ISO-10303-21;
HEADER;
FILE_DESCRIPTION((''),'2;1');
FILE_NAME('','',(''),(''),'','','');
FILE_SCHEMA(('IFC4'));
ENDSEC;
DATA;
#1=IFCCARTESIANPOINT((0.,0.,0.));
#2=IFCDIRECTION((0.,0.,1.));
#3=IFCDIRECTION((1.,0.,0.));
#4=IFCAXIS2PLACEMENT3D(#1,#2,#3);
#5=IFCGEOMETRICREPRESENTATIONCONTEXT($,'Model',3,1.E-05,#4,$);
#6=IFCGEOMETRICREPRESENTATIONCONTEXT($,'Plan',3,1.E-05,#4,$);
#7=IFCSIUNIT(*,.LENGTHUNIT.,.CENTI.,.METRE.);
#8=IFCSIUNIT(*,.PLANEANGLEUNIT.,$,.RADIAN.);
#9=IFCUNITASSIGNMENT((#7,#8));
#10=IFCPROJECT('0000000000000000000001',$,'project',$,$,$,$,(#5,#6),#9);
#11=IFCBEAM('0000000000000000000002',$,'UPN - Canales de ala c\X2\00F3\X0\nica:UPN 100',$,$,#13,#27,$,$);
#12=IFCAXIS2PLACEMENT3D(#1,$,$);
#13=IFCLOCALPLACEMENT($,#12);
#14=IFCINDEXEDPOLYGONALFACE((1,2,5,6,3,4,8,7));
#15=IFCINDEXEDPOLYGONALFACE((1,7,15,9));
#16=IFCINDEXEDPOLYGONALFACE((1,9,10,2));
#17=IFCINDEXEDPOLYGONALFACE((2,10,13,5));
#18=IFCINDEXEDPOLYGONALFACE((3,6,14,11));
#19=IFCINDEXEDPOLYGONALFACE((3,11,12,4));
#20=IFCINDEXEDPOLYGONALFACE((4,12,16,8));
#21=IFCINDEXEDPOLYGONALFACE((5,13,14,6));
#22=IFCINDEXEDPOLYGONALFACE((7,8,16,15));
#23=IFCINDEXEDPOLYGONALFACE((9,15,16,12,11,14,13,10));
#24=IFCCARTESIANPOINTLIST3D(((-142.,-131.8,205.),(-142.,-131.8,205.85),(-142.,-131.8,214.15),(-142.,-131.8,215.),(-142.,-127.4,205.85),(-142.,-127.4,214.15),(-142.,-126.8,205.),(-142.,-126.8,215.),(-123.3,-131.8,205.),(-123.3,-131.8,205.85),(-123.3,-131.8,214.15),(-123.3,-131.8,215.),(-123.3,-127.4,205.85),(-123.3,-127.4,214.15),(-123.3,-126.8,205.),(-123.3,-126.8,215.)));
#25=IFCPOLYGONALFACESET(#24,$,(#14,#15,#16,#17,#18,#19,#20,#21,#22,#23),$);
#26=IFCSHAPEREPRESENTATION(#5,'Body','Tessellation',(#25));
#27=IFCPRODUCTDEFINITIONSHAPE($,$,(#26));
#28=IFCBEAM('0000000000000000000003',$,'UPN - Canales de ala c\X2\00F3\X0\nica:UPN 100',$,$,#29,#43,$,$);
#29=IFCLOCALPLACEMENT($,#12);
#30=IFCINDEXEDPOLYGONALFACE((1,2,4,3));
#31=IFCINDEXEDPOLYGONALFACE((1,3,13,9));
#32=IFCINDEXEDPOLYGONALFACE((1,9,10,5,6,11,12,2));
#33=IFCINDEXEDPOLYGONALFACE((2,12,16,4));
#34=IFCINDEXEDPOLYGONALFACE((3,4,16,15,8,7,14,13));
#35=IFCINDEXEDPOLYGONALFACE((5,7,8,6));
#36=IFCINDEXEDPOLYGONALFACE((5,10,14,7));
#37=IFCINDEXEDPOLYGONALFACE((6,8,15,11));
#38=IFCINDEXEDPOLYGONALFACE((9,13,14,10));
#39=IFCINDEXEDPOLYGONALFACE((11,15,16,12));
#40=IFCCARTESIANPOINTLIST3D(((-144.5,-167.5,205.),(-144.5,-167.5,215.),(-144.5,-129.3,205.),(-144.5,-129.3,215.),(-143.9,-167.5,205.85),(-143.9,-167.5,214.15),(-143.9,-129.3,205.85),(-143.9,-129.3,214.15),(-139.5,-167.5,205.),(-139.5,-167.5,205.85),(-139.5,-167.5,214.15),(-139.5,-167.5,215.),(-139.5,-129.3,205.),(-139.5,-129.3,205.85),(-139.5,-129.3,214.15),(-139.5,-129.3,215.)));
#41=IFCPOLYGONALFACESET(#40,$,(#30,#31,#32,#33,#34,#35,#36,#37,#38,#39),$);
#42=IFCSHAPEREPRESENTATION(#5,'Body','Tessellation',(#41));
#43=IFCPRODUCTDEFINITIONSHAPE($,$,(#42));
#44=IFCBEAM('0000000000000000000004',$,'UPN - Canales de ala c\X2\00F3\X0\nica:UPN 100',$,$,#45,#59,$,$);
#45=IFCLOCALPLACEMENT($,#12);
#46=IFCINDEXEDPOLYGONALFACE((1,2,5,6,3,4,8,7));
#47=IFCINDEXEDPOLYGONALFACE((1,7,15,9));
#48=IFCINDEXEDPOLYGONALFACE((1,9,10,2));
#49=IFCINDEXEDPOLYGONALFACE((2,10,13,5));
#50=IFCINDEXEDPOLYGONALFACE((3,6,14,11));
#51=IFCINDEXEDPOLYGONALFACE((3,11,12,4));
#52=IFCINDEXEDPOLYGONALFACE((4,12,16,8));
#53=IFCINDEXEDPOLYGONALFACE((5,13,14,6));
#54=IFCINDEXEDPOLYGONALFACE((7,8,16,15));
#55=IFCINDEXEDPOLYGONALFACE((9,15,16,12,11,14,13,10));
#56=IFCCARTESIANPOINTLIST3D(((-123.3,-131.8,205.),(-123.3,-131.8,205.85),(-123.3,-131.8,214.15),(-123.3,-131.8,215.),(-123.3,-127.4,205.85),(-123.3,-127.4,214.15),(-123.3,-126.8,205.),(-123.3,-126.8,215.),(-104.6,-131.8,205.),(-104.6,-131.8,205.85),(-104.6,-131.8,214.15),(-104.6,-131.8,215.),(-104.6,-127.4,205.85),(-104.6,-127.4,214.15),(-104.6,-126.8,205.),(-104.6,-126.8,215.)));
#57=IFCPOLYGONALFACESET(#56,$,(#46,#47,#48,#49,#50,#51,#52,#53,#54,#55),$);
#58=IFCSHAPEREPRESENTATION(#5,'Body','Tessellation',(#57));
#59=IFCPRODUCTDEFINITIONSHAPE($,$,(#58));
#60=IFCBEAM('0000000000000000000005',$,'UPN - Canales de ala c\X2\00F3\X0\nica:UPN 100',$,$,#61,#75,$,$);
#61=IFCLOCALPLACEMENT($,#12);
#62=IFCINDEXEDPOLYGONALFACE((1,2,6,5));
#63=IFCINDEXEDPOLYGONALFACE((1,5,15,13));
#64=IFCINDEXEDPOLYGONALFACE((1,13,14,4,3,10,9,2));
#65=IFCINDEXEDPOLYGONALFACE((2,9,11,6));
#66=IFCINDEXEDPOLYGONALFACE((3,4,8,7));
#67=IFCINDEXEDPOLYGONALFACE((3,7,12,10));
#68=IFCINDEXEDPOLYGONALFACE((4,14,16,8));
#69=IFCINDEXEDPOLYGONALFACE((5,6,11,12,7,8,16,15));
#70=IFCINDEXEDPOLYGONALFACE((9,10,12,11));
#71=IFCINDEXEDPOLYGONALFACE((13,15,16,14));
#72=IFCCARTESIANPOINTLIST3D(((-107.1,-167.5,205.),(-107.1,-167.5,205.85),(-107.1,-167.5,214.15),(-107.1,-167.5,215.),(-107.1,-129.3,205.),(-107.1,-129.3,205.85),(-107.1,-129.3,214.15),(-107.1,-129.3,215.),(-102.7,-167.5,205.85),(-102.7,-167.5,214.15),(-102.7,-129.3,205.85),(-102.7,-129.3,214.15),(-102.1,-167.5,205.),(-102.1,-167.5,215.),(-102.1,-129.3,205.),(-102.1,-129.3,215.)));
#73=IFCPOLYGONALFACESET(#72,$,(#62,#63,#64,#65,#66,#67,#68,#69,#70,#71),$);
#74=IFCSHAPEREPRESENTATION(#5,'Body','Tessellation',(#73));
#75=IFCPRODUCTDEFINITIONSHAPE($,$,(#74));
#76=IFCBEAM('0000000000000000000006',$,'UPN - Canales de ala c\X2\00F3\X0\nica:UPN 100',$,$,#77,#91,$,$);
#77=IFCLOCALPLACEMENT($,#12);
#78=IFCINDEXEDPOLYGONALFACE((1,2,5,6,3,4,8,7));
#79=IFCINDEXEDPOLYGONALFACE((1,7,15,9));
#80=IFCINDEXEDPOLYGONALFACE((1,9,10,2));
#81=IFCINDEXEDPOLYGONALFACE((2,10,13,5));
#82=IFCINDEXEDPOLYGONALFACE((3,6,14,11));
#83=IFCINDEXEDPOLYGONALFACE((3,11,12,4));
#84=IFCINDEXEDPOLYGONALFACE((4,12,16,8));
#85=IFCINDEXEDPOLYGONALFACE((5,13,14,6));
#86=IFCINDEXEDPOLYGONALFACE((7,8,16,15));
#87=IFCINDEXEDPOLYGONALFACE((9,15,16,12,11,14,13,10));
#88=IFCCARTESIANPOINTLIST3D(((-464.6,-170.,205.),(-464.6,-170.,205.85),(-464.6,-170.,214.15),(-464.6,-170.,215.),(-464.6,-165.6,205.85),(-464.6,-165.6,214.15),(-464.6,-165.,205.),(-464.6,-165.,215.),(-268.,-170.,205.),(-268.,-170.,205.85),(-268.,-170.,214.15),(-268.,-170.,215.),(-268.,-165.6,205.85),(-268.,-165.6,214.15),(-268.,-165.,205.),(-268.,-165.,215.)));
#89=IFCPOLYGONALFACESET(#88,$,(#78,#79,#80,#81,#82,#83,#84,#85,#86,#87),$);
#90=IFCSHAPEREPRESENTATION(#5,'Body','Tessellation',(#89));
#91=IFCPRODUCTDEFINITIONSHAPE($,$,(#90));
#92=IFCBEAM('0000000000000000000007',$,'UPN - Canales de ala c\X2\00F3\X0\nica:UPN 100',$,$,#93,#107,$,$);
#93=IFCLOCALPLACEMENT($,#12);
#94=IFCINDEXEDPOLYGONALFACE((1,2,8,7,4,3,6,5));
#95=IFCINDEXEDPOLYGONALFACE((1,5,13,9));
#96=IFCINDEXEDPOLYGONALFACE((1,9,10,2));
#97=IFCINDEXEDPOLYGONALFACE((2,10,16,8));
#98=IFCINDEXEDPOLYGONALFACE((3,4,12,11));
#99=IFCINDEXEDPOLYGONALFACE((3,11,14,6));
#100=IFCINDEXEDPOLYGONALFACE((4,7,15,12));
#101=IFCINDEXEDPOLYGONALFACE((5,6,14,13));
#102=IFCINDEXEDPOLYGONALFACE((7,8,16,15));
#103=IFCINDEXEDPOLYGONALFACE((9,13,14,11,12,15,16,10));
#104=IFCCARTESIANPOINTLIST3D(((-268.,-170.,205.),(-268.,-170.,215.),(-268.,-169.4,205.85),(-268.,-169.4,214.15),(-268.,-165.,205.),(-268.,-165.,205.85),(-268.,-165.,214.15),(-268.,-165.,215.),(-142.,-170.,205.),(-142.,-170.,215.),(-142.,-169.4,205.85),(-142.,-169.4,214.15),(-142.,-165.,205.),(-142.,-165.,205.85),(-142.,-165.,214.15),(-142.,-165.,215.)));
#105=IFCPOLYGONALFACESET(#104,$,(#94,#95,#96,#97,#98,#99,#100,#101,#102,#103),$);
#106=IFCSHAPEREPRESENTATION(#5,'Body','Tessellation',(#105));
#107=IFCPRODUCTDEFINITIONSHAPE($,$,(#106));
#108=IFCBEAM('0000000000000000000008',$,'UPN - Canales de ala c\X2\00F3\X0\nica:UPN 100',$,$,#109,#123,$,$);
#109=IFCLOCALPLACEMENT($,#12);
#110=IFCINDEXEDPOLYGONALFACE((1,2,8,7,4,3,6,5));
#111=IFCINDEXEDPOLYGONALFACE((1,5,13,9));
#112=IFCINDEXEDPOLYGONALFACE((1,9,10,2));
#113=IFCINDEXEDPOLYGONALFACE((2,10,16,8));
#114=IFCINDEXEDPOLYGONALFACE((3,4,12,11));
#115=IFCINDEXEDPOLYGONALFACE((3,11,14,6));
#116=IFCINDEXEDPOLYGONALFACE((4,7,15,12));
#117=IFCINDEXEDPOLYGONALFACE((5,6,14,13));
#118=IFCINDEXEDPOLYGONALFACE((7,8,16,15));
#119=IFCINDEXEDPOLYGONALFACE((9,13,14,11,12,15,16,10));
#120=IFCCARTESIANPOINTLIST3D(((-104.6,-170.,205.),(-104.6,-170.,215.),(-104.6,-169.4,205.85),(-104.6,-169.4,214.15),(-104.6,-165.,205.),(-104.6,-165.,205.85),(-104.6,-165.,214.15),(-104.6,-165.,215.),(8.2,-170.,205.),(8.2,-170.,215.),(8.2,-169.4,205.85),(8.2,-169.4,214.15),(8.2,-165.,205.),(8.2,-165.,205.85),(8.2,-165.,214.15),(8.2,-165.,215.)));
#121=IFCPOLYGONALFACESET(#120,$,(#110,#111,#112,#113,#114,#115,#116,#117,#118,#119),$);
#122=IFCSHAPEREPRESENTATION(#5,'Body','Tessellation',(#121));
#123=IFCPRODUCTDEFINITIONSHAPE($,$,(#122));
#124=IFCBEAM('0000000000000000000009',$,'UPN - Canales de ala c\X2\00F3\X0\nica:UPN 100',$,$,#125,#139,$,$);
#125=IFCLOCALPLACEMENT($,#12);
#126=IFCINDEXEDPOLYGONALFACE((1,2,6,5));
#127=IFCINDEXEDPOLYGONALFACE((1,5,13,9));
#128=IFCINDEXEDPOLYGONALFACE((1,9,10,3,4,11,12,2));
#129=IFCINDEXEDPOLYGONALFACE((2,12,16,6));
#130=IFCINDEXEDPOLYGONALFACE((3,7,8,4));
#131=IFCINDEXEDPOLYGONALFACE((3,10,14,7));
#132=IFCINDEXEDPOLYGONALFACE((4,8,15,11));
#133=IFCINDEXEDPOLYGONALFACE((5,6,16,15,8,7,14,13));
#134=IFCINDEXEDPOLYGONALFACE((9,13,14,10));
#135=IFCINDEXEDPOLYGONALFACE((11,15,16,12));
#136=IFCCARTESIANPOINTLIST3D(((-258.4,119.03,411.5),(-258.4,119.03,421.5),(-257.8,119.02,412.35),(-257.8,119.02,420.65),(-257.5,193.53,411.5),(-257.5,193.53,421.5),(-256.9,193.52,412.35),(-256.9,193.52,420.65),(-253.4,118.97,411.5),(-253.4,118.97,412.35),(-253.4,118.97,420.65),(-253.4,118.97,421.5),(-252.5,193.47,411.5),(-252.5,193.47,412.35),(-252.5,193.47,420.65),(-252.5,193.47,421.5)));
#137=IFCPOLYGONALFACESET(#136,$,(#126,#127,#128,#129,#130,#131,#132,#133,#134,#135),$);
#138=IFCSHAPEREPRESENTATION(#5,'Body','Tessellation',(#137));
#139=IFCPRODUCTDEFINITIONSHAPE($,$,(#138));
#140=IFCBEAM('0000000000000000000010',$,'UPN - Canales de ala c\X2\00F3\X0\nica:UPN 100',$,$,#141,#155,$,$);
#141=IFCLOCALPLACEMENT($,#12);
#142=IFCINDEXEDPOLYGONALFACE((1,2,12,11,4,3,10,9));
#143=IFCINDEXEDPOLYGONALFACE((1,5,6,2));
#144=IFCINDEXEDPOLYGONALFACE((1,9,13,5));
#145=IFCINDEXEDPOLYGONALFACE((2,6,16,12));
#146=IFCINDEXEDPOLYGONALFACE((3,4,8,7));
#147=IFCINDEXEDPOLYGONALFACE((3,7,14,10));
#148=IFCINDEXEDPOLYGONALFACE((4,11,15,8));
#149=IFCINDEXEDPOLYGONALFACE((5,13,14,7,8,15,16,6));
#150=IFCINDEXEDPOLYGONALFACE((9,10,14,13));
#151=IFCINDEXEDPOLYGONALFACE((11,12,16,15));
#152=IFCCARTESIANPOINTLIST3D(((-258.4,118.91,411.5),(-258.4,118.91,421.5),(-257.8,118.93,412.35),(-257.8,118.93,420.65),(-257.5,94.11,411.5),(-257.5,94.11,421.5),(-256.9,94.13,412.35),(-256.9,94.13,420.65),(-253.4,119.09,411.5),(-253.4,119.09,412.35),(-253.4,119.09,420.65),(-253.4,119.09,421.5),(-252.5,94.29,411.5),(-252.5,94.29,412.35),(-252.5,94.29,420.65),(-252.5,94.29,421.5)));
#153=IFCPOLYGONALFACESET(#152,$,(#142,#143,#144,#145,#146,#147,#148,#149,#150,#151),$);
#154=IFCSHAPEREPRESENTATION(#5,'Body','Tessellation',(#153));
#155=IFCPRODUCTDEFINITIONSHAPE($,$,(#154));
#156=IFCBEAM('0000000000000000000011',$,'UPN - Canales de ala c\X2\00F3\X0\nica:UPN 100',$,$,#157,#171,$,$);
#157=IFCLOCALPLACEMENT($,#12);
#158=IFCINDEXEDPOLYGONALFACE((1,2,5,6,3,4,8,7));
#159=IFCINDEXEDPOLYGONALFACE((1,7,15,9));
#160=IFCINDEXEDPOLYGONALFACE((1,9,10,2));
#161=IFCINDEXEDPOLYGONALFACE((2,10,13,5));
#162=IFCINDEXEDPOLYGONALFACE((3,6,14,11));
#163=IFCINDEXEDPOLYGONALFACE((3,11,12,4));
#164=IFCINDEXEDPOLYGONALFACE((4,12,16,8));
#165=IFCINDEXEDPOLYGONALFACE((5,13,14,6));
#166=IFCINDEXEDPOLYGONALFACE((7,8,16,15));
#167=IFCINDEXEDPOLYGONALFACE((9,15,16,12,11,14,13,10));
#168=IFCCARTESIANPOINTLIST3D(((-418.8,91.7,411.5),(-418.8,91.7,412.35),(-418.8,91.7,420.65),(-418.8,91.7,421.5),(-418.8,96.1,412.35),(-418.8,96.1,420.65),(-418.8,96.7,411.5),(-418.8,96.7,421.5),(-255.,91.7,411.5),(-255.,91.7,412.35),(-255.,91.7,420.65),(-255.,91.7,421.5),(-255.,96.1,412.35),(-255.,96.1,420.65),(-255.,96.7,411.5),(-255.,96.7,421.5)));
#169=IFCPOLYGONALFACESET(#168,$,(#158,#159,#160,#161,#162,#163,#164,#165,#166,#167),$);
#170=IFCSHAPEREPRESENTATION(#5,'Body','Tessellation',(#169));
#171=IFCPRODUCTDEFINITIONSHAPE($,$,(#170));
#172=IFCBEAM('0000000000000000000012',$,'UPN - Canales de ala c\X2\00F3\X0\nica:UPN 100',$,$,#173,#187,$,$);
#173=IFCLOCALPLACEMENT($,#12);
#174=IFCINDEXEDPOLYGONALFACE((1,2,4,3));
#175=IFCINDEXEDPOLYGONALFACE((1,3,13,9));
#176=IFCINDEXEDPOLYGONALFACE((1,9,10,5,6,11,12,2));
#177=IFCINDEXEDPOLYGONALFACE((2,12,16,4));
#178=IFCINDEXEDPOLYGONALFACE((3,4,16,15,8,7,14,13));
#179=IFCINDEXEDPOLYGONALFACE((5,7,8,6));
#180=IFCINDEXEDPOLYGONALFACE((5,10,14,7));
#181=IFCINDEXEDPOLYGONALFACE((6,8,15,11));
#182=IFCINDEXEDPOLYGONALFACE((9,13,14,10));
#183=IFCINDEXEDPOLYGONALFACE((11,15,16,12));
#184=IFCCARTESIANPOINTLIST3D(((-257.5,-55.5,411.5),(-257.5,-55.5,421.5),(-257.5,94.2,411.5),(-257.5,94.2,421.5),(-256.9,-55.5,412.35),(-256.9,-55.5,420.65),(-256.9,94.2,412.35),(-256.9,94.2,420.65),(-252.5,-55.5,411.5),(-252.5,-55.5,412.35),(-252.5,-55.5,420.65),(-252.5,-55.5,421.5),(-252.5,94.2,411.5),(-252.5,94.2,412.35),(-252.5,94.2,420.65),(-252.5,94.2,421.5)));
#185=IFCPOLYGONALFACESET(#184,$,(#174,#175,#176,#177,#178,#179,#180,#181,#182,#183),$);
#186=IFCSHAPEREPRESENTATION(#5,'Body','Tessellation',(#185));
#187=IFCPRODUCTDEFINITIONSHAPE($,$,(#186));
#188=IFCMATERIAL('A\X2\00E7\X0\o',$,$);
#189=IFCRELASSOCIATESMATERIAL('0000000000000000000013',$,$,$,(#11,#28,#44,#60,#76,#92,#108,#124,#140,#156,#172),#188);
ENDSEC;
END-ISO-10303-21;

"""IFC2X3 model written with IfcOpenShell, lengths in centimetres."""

from ifc_helpers import new_model, si_unit, frame, frame_2d, origin_with_axes, origin_2d_with_axis, place, context, project, u_section, extrude, material, element, save


model = new_model("IFC2X3")

# Units and contexts
model_context = context("Model", 3, precision=1e-05, world=origin_with_axes())
plan_context = context("Plan", 3, precision=1e-05, world=origin_with_axes())
ifc_project = project(units=[si_unit("LENGTHUNIT", "METRE", prefix="CENTI"), si_unit("PLANEANGLEUNIT", "RADIAN")], contexts=[model_context, plan_context])

# Shared definitions
ifc_material = material(Name="Aço")

# Beams
beam_1_placement = place(None, frame((-123.3, -129.3, 210.0), z_axis=(-1.0, 0.0, 0.0), x_axis=(0.0, -1.0, 0.0)))
element("IfcBeam", 1, at=beam_1_placement, material=ifc_material, Name="UPN - Canales de ala cónica:UPN 100", context=model_context, shape_type="SweptSolid", body=[
    extrude(u_section(Depth=10.0, FlangeWidth=5.0, WebThickness=0.6, FlangeThickness=0.85, FilletRadius=0.0, EdgeRadius=0.0, FlangeSlope=0.0, CentreOfGravityInX=0.0, at=origin_2d_with_axis()), origin_with_axes(), (0.0, 0.0, 1.0), 18.7),
])
beam_2_placement = place(None, frame((-142.0, -167.5, 210.0), z_axis=(0.0, 1.0, 0.0), x_axis=(1.0, 0.0, 0.0)))
element("IfcBeam", 2, at=beam_2_placement, material=ifc_material, Name="UPN - Canales de ala cónica:UPN 100", context=model_context, shape_type="SweptSolid", body=[
    extrude(u_section(Depth=10.0, FlangeWidth=5.0, WebThickness=0.6, FlangeThickness=0.85, FilletRadius=0.0, EdgeRadius=0.0, FlangeSlope=0.0, CentreOfGravityInX=0.0, at=origin_2d_with_axis()), origin_with_axes(), (0.0, 0.0, 1.0), 38.2),
])
beam_3_placement = place(None, frame((-104.6, -129.3, 210.0), z_axis=(-1.0, 0.0, 0.0), x_axis=(0.0, -1.0, 0.0)))
element("IfcBeam", 3, at=beam_3_placement, material=ifc_material, Name="UPN - Canales de ala cónica:UPN 100", context=model_context, shape_type="SweptSolid", body=[
    extrude(u_section(Depth=10.0, FlangeWidth=5.0, WebThickness=0.6, FlangeThickness=0.85, FilletRadius=0.0, EdgeRadius=0.0, FlangeSlope=0.0, CentreOfGravityInX=0.0, at=origin_2d_with_axis()), origin_with_axes(), (0.0, 0.0, 1.0), 18.7),
])
beam_4_placement = place(None, frame((-104.6, -167.5, 210.0), z_axis=(0.0, 1.0, 0.0), x_axis=(-1.0, 0.0, 0.0)))
element("IfcBeam", 4, at=beam_4_placement, material=ifc_material, Name="UPN - Canales de ala cónica:UPN 100", context=model_context, shape_type="SweptSolid", body=[
    extrude(u_section(Depth=10.0, FlangeWidth=5.0, WebThickness=0.6, FlangeThickness=0.85, FilletRadius=0.0, EdgeRadius=0.0, FlangeSlope=0.0, CentreOfGravityInX=0.0, at=origin_2d_with_axis()), origin_with_axes(), (0.0, 0.0, 1.0), 38.2),
])
beam_5_placement = place(None, frame((-268.0, -167.5, 210.0), z_axis=(-1.0, 0.0, 0.0), x_axis=(0.0, -1.0, 0.0)))
element("IfcBeam", 5, at=beam_5_placement, material=ifc_material, Name="UPN - Canales de ala cónica:UPN 100", context=model_context, shape_type="SweptSolid", body=[
    extrude(u_section(Depth=10.0, FlangeWidth=5.0, WebThickness=0.6, FlangeThickness=0.85, FilletRadius=0.0, EdgeRadius=0.0, FlangeSlope=0.0, CentreOfGravityInX=0.0, at=origin_2d_with_axis()), origin_with_axes(), (0.0, 0.0, 1.0), 196.6),
])
beam_6_placement = place(None, frame((-142.0, -167.5, 210.0), z_axis=(-1.0, 0.0, 0.0), x_axis=(0.0, 1.0, 0.0)))
element("IfcBeam", 6, at=beam_6_placement, material=ifc_material, Name="UPN - Canales de ala cónica:UPN 100", context=model_context, shape_type="SweptSolid", body=[
    extrude(u_section(Depth=10.0, FlangeWidth=5.0, WebThickness=0.6, FlangeThickness=0.85, FilletRadius=0.0, EdgeRadius=0.0, FlangeSlope=0.0, CentreOfGravityInX=0.0, at=origin_2d_with_axis()), origin_with_axes(), (0.0, 0.0, 1.0), 126.0),
])
beam_7_placement = place(None, frame((8.2, -167.5, 210.0), z_axis=(-1.0, 0.0, 0.0), x_axis=(0.0, 1.0, 0.0)))
element("IfcBeam", 7, at=beam_7_placement, material=ifc_material, Name="UPN - Canales de ala cónica:UPN 100", context=model_context, shape_type="SweptSolid", body=[
    extrude(u_section(Depth=10.0, FlangeWidth=5.0, WebThickness=0.6, FlangeThickness=0.85, FilletRadius=0.0, EdgeRadius=0.0, FlangeSlope=0.0, CentreOfGravityInX=0.0, at=origin_2d_with_axis()), origin_with_axes(), (0.0, 0.0, 1.0), 112.8),
])
beam_8_placement = place(None, frame((-255.9, 119.0, 416.5), z_axis=(0.01208, 0.999927, 0.0), x_axis=(0.999927, -0.01208, 0.0)))
element("IfcBeam", 8, at=beam_8_placement, material=ifc_material, Name="UPN - Canales de ala cónica:UPN 100", context=model_context, shape_type="SweptSolid", body=[
    extrude(u_section(Depth=10.0, FlangeWidth=5.0, WebThickness=0.6, FlangeThickness=0.85, FilletRadius=0.0, EdgeRadius=0.0, FlangeSlope=0.0, CentreOfGravityInX=0.0, at=frame_2d((0.0, 0.0), x_axis=(1.0, 0.0))), origin_with_axes(), (0.0, 0.0, 1.0), 74.51),
])
beam_9_placement = place(None, frame((-255.0, 94.2, 416.5), z_axis=(-0.036267, 0.999342, 0.0), x_axis=(0.999342, 0.036267, 0.0)))
element("IfcBeam", 9, at=beam_9_placement, material=ifc_material, Name="UPN - Canales de ala cónica:UPN 100", context=model_context, shape_type="SweptSolid", body=[
    extrude(u_section(Depth=10.0, FlangeWidth=5.0, WebThickness=0.6, FlangeThickness=0.85, FilletRadius=0.0, EdgeRadius=0.0, FlangeSlope=0.0, CentreOfGravityInX=0.0, at=frame_2d((0.0, 0.0), x_axis=(1.0, 0.0))), origin_with_axes(), (0.0, 0.0, 1.0), 24.82),
])
beam_10_placement = place(None, frame((-255.0, 94.2, 416.5), z_axis=(-1.0, 0.0, 0.0), x_axis=(0.0, -1.0, 0.0)))
element("IfcBeam", 10, at=beam_10_placement, material=ifc_material, Name="UPN - Canales de ala cónica:UPN 100", context=model_context, shape_type="SweptSolid", body=[
    extrude(u_section(Depth=10.0, FlangeWidth=5.0, WebThickness=0.6, FlangeThickness=0.85, FilletRadius=0.0, EdgeRadius=0.0, FlangeSlope=0.0, CentreOfGravityInX=0.0, at=origin_2d_with_axis()), origin_with_axes(), (0.0, 0.0, 1.0), 163.8),
])
beam_11_placement = place(None, frame((-255.0, -55.5, 416.5), z_axis=(0.0, 1.0, 0.0), x_axis=(1.0, 0.0, 0.0)))
element("IfcBeam", 11, at=beam_11_placement, material=ifc_material, Name="UPN - Canales de ala cónica:UPN 100", context=model_context, shape_type="SweptSolid", body=[
    extrude(u_section(Depth=10.0, FlangeWidth=5.0, WebThickness=0.6, FlangeThickness=0.85, FilletRadius=0.0, EdgeRadius=0.0, FlangeSlope=0.0, CentreOfGravityInX=0.0, at=origin_2d_with_axis()), origin_with_axes(), (0.0, 0.0, 1.0), 149.7),
])

save(model, "model.ifc")
